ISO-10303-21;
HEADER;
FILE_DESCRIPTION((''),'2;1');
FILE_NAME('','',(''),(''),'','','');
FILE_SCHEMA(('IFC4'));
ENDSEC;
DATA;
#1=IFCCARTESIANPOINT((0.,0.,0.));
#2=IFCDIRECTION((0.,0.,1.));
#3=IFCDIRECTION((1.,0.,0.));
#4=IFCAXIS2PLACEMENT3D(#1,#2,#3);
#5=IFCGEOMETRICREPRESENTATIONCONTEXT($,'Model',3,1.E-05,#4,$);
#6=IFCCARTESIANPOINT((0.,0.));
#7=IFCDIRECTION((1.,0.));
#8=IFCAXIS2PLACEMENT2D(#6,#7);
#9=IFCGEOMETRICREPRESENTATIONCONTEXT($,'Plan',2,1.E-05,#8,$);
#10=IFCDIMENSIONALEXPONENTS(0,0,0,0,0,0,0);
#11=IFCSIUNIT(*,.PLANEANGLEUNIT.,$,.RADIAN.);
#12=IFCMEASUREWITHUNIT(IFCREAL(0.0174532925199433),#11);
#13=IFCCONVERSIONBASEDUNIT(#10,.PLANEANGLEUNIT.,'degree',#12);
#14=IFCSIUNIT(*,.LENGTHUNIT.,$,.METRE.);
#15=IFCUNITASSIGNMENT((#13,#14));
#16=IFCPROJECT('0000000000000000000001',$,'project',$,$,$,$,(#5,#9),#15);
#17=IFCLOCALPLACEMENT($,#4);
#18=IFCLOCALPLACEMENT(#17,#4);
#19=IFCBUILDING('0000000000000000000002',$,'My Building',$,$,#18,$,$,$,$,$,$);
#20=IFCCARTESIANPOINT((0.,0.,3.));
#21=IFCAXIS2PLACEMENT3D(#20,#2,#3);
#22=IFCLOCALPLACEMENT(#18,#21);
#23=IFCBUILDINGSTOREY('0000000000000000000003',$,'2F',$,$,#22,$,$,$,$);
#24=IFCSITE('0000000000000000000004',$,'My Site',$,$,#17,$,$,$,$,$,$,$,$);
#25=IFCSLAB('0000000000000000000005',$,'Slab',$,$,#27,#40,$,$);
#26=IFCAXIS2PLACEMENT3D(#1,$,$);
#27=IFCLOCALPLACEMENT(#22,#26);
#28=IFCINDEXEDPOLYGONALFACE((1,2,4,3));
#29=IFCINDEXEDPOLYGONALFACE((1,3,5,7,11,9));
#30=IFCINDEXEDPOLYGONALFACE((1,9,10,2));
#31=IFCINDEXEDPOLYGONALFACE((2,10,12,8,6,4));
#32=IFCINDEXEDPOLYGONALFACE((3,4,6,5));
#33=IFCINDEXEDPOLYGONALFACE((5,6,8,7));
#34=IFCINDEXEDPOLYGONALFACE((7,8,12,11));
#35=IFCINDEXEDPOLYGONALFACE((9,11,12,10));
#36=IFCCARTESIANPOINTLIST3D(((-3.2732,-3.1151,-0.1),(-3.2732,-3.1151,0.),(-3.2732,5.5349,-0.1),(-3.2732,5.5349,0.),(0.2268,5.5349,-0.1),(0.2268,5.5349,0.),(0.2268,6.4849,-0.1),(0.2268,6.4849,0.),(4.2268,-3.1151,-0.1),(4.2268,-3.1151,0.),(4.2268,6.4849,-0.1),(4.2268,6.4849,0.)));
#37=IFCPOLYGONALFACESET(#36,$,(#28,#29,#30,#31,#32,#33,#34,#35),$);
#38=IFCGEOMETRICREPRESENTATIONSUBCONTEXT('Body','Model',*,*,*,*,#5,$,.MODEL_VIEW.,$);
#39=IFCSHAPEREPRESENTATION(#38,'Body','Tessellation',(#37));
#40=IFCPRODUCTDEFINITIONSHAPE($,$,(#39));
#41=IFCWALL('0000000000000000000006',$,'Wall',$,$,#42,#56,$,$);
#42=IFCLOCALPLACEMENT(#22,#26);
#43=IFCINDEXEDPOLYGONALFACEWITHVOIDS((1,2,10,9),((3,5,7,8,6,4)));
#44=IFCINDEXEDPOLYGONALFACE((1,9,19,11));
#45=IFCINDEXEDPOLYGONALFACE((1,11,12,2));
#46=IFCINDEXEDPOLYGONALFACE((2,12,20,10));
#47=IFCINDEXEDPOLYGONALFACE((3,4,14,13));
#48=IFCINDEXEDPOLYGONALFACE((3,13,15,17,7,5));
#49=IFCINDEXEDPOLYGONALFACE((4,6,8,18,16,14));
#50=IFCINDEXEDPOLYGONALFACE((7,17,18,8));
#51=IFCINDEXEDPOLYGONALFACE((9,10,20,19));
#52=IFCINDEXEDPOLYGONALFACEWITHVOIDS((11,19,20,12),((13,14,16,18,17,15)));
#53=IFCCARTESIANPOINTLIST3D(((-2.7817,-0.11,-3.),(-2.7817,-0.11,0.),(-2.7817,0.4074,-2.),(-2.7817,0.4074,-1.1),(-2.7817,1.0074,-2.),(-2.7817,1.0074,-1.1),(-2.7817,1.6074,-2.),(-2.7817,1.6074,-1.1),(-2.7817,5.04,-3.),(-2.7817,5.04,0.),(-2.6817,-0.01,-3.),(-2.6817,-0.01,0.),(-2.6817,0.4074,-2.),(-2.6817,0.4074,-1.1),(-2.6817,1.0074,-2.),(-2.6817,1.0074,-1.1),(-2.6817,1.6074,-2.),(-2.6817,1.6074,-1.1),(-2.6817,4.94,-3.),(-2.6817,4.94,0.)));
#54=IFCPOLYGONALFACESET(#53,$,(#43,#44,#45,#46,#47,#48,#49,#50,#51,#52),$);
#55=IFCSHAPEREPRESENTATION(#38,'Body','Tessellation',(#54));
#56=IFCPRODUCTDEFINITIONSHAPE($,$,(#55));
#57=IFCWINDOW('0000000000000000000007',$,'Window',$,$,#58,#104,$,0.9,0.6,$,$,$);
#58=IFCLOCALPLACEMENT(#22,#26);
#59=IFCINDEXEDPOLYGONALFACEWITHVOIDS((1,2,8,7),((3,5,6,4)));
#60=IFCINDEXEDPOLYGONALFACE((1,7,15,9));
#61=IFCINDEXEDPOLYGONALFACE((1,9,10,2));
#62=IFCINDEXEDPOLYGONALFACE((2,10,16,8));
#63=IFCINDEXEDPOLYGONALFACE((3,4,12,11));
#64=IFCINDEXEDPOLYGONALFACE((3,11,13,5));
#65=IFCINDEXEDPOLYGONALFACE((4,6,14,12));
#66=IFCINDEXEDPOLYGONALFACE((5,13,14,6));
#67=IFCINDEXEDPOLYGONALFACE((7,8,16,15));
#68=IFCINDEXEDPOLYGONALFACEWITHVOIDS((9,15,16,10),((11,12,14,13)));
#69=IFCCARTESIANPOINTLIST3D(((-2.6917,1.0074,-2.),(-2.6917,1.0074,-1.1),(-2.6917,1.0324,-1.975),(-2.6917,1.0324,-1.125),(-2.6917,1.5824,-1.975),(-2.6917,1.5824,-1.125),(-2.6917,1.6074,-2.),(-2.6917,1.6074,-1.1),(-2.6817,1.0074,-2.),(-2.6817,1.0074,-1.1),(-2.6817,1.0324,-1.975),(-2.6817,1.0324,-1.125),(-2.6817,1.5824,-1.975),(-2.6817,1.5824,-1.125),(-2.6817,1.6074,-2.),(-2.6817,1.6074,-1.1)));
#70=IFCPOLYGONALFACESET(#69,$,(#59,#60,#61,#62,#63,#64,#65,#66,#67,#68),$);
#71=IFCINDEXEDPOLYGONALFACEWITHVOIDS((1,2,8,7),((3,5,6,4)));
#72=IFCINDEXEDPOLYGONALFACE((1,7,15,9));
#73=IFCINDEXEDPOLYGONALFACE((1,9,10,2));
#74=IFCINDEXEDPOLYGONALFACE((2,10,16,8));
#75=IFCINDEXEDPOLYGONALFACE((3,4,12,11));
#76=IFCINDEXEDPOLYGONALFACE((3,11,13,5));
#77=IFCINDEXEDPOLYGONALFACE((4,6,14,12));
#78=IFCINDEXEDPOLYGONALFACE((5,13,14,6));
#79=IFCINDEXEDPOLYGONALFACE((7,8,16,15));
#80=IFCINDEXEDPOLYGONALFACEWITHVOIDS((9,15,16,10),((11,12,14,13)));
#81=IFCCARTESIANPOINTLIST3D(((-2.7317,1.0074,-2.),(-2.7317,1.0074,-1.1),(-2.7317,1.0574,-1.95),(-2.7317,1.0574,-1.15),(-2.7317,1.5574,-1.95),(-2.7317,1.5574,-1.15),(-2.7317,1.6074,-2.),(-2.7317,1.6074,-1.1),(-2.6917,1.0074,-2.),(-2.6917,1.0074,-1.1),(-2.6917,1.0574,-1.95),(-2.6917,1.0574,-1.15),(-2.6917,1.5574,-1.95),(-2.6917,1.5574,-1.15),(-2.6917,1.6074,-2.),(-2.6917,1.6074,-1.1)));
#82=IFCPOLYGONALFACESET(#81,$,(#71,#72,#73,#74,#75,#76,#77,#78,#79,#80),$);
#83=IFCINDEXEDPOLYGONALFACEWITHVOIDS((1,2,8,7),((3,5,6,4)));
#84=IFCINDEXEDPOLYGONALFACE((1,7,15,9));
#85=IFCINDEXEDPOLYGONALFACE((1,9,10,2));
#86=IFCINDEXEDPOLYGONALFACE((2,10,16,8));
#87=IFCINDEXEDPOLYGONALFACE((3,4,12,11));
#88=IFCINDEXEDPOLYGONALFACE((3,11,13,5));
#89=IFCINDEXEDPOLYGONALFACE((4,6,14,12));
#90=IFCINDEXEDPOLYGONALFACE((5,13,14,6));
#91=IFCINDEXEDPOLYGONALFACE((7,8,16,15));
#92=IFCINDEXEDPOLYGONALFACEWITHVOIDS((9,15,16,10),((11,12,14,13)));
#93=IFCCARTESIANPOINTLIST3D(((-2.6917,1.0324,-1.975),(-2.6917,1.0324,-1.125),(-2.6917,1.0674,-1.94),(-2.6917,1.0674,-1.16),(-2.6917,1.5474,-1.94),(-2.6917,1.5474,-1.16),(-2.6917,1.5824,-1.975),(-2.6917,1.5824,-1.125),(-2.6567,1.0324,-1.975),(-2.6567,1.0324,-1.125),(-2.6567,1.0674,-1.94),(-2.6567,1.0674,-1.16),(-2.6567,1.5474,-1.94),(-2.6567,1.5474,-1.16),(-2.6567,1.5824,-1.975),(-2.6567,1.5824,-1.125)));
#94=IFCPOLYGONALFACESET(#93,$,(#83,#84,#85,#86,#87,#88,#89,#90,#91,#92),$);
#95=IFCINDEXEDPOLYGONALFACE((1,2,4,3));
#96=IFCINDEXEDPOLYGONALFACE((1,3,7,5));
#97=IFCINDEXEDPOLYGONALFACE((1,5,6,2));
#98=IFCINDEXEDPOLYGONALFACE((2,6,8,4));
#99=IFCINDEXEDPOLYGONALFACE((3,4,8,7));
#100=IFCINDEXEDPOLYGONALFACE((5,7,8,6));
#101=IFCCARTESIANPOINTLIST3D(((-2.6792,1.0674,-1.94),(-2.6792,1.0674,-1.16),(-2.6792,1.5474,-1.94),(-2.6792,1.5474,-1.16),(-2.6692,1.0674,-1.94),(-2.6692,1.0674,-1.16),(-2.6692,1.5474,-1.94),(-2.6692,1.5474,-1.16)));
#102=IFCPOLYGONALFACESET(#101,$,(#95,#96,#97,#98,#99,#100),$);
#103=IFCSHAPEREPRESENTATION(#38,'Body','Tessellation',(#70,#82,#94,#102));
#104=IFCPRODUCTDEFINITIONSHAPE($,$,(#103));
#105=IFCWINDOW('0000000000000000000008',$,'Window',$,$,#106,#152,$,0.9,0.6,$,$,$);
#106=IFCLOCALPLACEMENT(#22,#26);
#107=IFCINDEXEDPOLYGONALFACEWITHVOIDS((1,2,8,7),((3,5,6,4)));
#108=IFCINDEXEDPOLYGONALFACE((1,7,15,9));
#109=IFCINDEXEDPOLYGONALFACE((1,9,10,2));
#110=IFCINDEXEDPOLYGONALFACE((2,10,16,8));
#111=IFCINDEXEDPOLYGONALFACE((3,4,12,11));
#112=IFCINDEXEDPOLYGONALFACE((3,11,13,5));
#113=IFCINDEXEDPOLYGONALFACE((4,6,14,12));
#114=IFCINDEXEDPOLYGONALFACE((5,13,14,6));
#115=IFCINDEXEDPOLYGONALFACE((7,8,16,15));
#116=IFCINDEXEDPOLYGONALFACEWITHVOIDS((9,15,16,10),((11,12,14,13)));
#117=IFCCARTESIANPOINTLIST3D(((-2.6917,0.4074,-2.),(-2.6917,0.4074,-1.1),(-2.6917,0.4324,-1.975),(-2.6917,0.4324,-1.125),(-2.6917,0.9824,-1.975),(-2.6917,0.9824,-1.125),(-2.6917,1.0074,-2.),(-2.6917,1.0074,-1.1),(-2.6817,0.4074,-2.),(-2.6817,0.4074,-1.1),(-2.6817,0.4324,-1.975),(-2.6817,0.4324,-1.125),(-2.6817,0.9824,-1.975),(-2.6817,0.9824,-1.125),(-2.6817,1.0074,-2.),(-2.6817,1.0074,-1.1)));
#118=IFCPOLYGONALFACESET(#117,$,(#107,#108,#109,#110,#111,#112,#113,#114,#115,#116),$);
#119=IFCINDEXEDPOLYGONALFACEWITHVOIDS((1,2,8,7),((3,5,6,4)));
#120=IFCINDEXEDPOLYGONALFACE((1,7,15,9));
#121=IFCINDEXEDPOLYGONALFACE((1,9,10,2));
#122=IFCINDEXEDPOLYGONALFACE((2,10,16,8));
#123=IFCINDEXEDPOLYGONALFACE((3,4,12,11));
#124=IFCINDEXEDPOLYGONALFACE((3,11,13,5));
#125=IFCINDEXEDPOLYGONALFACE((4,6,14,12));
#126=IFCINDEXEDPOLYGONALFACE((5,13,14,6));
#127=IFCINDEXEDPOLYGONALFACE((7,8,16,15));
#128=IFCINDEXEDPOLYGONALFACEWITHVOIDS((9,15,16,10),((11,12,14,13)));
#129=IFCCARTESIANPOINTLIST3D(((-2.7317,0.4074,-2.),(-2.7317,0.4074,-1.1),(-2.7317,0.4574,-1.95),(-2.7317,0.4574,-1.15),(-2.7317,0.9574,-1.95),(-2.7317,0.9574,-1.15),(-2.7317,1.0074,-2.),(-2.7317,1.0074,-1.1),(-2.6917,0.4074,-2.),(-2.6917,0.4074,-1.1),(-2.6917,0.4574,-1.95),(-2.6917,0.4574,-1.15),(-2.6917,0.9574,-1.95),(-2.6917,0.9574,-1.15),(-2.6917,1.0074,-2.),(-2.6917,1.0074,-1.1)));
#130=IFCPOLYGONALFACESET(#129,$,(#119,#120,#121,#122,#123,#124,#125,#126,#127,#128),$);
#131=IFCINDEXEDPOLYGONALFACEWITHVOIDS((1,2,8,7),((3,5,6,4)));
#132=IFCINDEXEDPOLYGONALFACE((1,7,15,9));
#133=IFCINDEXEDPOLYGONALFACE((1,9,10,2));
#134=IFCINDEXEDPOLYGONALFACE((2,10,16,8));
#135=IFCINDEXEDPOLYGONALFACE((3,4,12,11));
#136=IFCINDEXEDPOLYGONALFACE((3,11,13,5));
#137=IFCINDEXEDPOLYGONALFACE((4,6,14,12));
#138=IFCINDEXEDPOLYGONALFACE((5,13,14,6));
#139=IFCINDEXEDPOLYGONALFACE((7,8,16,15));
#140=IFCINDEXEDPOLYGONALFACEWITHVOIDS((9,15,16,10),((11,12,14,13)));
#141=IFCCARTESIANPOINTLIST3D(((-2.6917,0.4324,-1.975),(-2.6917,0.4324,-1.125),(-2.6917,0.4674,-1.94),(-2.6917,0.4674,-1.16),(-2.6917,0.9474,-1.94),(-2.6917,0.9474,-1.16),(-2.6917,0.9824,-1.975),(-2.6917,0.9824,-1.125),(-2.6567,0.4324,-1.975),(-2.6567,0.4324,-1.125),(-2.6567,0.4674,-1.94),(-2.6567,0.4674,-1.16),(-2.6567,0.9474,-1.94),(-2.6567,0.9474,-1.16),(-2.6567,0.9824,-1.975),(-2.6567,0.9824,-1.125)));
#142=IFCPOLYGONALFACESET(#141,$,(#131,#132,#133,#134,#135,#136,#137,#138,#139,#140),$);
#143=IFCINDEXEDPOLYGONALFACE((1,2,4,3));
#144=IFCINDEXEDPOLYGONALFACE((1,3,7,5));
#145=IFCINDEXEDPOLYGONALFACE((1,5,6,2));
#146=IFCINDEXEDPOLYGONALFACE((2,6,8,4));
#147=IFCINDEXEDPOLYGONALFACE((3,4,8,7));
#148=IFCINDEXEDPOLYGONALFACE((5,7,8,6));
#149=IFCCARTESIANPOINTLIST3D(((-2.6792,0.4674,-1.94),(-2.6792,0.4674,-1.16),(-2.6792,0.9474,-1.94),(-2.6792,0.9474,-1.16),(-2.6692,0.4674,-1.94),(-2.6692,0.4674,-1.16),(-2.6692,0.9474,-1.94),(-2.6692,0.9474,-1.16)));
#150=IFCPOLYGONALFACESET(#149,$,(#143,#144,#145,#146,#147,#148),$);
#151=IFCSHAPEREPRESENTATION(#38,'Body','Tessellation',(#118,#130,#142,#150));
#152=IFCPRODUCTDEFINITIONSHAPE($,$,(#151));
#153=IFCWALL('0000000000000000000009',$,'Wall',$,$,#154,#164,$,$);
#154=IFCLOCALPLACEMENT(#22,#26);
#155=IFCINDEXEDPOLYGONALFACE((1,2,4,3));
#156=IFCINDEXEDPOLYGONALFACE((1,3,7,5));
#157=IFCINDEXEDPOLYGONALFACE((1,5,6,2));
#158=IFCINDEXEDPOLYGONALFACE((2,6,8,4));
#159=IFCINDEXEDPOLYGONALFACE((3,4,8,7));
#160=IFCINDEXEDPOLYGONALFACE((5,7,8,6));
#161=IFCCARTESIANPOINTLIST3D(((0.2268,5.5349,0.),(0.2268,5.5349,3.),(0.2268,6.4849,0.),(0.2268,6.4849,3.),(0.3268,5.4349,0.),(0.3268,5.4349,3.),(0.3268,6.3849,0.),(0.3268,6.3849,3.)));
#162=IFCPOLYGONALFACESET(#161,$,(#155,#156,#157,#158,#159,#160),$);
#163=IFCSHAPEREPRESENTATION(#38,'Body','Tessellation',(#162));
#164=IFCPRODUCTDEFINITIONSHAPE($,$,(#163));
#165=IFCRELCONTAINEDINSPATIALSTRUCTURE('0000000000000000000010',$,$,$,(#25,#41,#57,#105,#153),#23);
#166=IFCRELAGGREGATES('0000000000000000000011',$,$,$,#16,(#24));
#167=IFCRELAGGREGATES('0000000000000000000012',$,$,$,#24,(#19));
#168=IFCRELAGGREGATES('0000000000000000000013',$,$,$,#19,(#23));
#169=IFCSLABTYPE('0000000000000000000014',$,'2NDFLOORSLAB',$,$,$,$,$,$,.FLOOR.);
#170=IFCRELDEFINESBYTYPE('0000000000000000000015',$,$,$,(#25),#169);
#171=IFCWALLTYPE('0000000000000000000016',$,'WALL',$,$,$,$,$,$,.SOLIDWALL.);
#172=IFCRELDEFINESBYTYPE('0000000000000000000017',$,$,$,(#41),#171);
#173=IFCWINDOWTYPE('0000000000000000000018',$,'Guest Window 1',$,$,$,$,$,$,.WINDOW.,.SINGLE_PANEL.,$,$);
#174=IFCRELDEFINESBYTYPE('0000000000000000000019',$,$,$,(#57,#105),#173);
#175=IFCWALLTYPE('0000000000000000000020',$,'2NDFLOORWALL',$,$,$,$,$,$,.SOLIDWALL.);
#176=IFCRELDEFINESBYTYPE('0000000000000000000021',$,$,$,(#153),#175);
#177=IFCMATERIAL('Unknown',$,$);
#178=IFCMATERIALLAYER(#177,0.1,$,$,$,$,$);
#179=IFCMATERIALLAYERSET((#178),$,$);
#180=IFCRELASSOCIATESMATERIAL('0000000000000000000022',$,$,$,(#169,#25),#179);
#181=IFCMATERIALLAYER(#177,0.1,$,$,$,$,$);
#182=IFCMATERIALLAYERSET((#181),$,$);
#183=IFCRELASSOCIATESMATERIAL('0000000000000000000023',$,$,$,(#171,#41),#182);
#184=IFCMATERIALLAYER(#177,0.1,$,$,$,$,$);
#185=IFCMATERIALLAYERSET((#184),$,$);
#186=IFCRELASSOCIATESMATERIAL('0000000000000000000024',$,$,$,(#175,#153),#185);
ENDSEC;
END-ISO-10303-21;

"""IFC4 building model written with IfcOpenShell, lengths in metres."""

from ifc_helpers import new_model, entity, si_unit, converted_unit, frame, origin_with_axes, origin_2d_with_axis, place, context, subcontext, project, spatial, line, indexed_curve, outline, extrude, shape, source, transform, mapped, material, layer, layer_set, layer_usage, type_object, type_shapes, element, fill, save


model = new_model("IFC4")

# Units and contexts
model_context = context("Model", 3, precision=1e-05, world=origin_with_axes())
plan_context = context("Plan", 2, precision=1e-05, world=origin_2d_with_axis())
body_context_1 = subcontext(model_context, "Body", "Model", "MODEL_VIEW")
body_context_2 = subcontext(plan_context, "Body", "Plan", "PLAN_VIEW")
ifc_project = project(units=[converted_unit("PLANEANGLEUNIT", "degree", entity("IfcReal", 0.0174532925199433), si_unit("PLANEANGLEUNIT", "RADIAN"), dimensions=[0, 0, 0, 0, 0, 0, 0]), si_unit("LENGTHUNIT", "METRE")], contexts=[model_context, plan_context])

# Site, building, storey
site_placement = place(None, origin_with_axes())
site = spatial("IfcSite", under=ifc_project, at=site_placement, Name="My Site")
building_placement = place(site_placement, origin_with_axes())
building = spatial("IfcBuilding", under=site, at=building_placement, Name="My Building")
storey_placement = place(building_placement, frame((0.0, 0.0, 3.0), z_axis=(0.0, 0.0, 1.0), x_axis=(1.0, 0.0, 0.0)))
storey = spatial("IfcBuildingStorey", under=building, at=storey_placement, Name="2F")

# Slab
ifc_material = material(Name="Unknown")
ifc_layer_1 = layer(ifc_material, 0.1)
ifc_layer_set_1 = layer_set([ifc_layer_1])
ifc_layer_usage_1 = layer_usage(ifc_layer_set_1, "AXIS3", "POSITIVE", -0.1)
slab_type = type_object("IfcSlabType", Name="2NDFLOORSLAB", PredefinedType="FLOOR", material=ifc_layer_set_1)
slab_placement = place(storey_placement, frame((-3.2732, 5.5349, 0.0), z_axis=(0.0, 0.0, 1.0), x_axis=(1.0, 0.0, 0.0)))
element("IfcSlab", 1, at=slab_placement, inside=storey, type_object=slab_type, material=ifc_layer_usage_1, Name="Slab", context=body_context_1, shape_type="SweptSolid", body=[
    extrude(outline(indexed_curve([(0.0, 0.0), (3.5, 0.0), (3.5, 0.95), (7.5, 0.95), (7.5, -8.65), (0.0, -8.65), (0.0, 0.0)])), frame((0.0, 0.0, -0.1), z_axis=(0.0, 0.0, 1.0), x_axis=(1.0, 0.0, 0.0)), (0.0, 0.0, 1.0), 0.1),
])

# Wall, openings, windows
ifc_layer_2 = layer(ifc_material, 0.1)
ifc_layer_set_2 = layer_set([ifc_layer_2])
ifc_layer_usage_2 = layer_usage(ifc_layer_set_2, "AXIS2", "POSITIVE", 0.0)
wall_type_1 = type_object("IfcWallType", Name="WALL", PredefinedType="SOLIDWALL", material=ifc_layer_set_2)
wall_1_placement = place(storey_placement, frame((-2.7817, 5.04, -3.0), z_axis=(0.0, 0.0, 1.0), x_axis=(0.0, -1.0, 0.0)))
wall_1 = element("IfcWall", 2, at=wall_1_placement, inside=storey, type_object=wall_type_1, material=ifc_layer_usage_2, Name="Wall", context=body_context_1, shape_type="SweptSolid", body=[
    extrude(outline(indexed_curve([(0.0, 0.0), (0.1, 0.1), (5.05, 0.1), (5.15, 0.0)], segments=[line(1, 2, 3, 4, 1)])), origin_with_axes(), (0.0, 0.0, 1.0), 3.0),
])
shared_shape_1 = source(origin_with_axes(), body_context_1, "Body", "SweptSolid", [
    extrude(outline(indexed_curve([(0.0, 0.0), (0.6, 0.0), (0.6, 0.9), (0.0, 0.9)], segments=[line(1, 2, 3, 4, 1)])), frame((0.0, -0.6, 0.0), z_axis=(0.0, -1.0, 0.0), x_axis=(1.0, 0.0, 0.0)), (0.0, 0.0, -1.0), 1.2),
])
opening_1_placement = place(wall_1_placement, frame((3.4326, 0.0, 1.0), z_axis=(0.0, 0.0, 1.0), x_axis=(1.0, 0.0, 0.0)))
opening_1 = element("IfcOpeningElement", 3, at=opening_1_placement, cuts=wall_1, PredefinedType="OPENING", context=body_context_1, shape_type="MappedRepresentation", body=[
    mapped(shared_shape_1, transform((0.0, 0.0, 0.0), x_axis=(1.0, 0.0, 0.0), y_axis=(0.0, 1.0, 0.0), z_axis=(0.0, 0.0, 1.0), scale=1.0)),
])
opening_2_placement = place(wall_1_placement, frame((4.0326, 0.0, 1.0), z_axis=(0.0, 0.0, 1.0), x_axis=(1.0, 0.0, 0.0)))
opening_2 = element("IfcOpeningElement", 4, at=opening_2_placement, cuts=wall_1, PredefinedType="OPENING", context=body_context_1, shape_type="MappedRepresentation", body=[
    mapped(shared_shape_1, transform((0.0, 0.0, 0.0), x_axis=(1.0, 0.0, 0.0), y_axis=(0.0, 1.0, 0.0), z_axis=(0.0, 0.0, 1.0), scale=1.0)),
])
window_type_1 = type_object("IfcWindowType", Name="Guest Window 1", PartitioningType="SINGLE_PANEL", PredefinedType="WINDOW")
shared_shape_2 = source(origin_with_axes(), body_context_1, "Body", "SweptSolid", [
    extrude(outline(indexed_curve([(0.0, 0.0), (0.6, 0.0), (0.6, 0.9), (0.0, 0.9)], segments=[line(1, 2, 3, 4, 1)]), holes=[indexed_curve([(0.025, 0.025), (0.575, 0.025), (0.575, 0.875), (0.025, 0.875)], segments=[line(1, 2, 3, 4, 1)])]), frame((0.0, 0.09, 0.0), z_axis=(0.0, -1.0, 0.0), x_axis=(1.0, 0.0, 0.0)), (0.0, 0.0, -1.0), 0.01),
    extrude(outline(indexed_curve([(0.0, 0.0), (0.6, 0.0), (0.6, 0.9), (0.0, 0.9)], segments=[line(1, 2, 3, 4, 1)]), holes=[indexed_curve([(0.05, 0.05), (0.55, 0.05), (0.55, 0.85), (0.05, 0.85)], segments=[line(1, 2, 3, 4, 1)])]), frame((0.0, 0.05, 0.0), z_axis=(0.0, -1.0, 0.0), x_axis=(1.0, 0.0, 0.0)), (0.0, 0.0, -1.0), 0.04),
    extrude(outline(indexed_curve([(0.0, 0.0), (0.55, 0.0), (0.55, 0.85), (0.0, 0.85)], segments=[line(1, 2, 3, 4, 1)]), holes=[indexed_curve([(0.035, 0.035), (0.515, 0.035), (0.515, 0.815), (0.035, 0.815)], segments=[line(1, 2, 3, 4, 1)])]), frame((0.025, 0.09, 0.025), z_axis=(0.0, -1.0, 0.0), x_axis=(1.0, 0.0, 0.0)), (0.0, 0.0, -1.0), 0.035),
    extrude(outline(indexed_curve([(0.035, 0.035), (0.515, 0.035), (0.515, 0.815), (0.035, 0.815)], segments=[line(1, 2, 3, 4, 1)])), frame((0.025, 0.1025, 0.025), z_axis=(0.0, -1.0, 0.0), x_axis=(1.0, 0.0, 0.0)), (0.0, 0.0, -1.0), 0.01),
])
shared_shape_3 = source(origin_with_axes(), body_context_2, "Body", "Curve2D", [
    entity("IfcIndexedPolyCurve", entity("IfcCartesianPointList2D", [[0.05, 0.05], [0.55, 0.05]])),
    entity("IfcIndexedPolyCurve", entity("IfcCartesianPointList2D", [[0.0, 0.1], [0.025, 0.1], [0.025, 0.09], [0.05, 0.09], [0.05, 0.05], [0.0, 0.05]]), [entity("IfcLineIndex", [1, 2, 3, 4, 5, 6, 1])]),
    entity("IfcIndexedPolyCurve", entity("IfcCartesianPointList2D", [[0.6, 0.1], [0.575, 0.1], [0.575, 0.09], [0.55, 0.09], [0.55, 0.05], [0.6, 0.05]]), [entity("IfcLineIndex", [1, 2, 3, 4, 5, 6, 1])]),
    entity("IfcIndexedPolyCurve", entity("IfcCartesianPointList2D", [[0.025, 0.09], [0.06, 0.09], [0.06, 0.125], [0.025, 0.125]]), [entity("IfcLineIndex", [1, 2, 3, 4, 1])]),
    entity("IfcIndexedPolyCurve", entity("IfcCartesianPointList2D", [[0.575, 0.09], [0.54, 0.09], [0.54, 0.125], [0.575, 0.125]]), [entity("IfcLineIndex", [1, 2, 3, 4, 1])]),
    entity("IfcIndexedPolyCurve", entity("IfcCartesianPointList2D", [[0.06, 0.09], [0.54, 0.09]])),
    entity("IfcIndexedPolyCurve", entity("IfcCartesianPointList2D", [[0.06, 0.125], [0.54, 0.125]])),
    entity("IfcIndexedPolyCurve", entity("IfcCartesianPointList2D", [[0.06, 0.1075], [0.54, 0.1075]])),
])
type_shapes(window_type_1, [shared_shape_2, shared_shape_3])
window_1_placement = place(opening_1_placement, frame((0.0, 0.0, 0.0), z_axis=(0.0, 0.0, 1.0), x_axis=(1.0, 0.0, 0.0)))
window_1 = element("IfcWindow", 5, at=window_1_placement, inside=storey, type_object=window_type_1, Name="Window", OverallHeight=0.9, OverallWidth=0.6, shapes=[
    shape(body_context_1, "Body", "MappedRepresentation", [mapped(shared_shape_2, transform((0.0, 0.0, 0.0), x_axis=(1.0, 0.0, 0.0), y_axis=(0.0, 1.0, 0.0), z_axis=(0.0, 0.0, 1.0), scale=1.0))]),
    shape(body_context_2, "Body", "MappedRepresentation", [mapped(shared_shape_3, transform((0.0, 0.0, 0.0), x_axis=(1.0, 0.0, 0.0), y_axis=(0.0, 1.0, 0.0), z_axis=(0.0, 0.0, 1.0), scale=1.0))]),
])
fill(opening_1, window_1)
window_2_placement = place(opening_2_placement, frame((0.0, 0.0, 0.0), z_axis=(0.0, 0.0, 1.0), x_axis=(1.0, 0.0, 0.0)))
window_2 = element("IfcWindow", 6, at=window_2_placement, inside=storey, type_object=window_type_1, Name="Window", OverallHeight=0.9, OverallWidth=0.6, shapes=[
    shape(body_context_1, "Body", "MappedRepresentation", [mapped(shared_shape_2, transform((0.0, 0.0, 0.0), x_axis=(1.0, 0.0, 0.0), y_axis=(0.0, 1.0, 0.0), z_axis=(0.0, 0.0, 1.0), scale=1.0))]),
    shape(body_context_2, "Body", "MappedRepresentation", [mapped(shared_shape_3, transform((0.0, 0.0, 0.0), x_axis=(1.0, 0.0, 0.0), y_axis=(0.0, 1.0, 0.0), z_axis=(0.0, 0.0, 1.0), scale=1.0))]),
])
fill(opening_2, window_2)

# Wall
ifc_layer_3 = layer(ifc_material, 0.1)
ifc_layer_set_3 = layer_set([ifc_layer_3])
ifc_layer_usage_3 = layer_usage(ifc_layer_set_3, "AXIS2", "POSITIVE", 0.0)
wall_type_2 = type_object("IfcWallType", Name="2NDFLOORWALL", PredefinedType="SOLIDWALL", material=ifc_layer_set_3)
wall_2_placement = place(storey_placement, frame((0.2268, 6.4849, 0.0), z_axis=(0.0, 0.0, 1.0), x_axis=(0.0, -1.0, 0.0)))
element("IfcWall", 7, at=wall_2_placement, inside=storey, type_object=wall_type_2, material=ifc_layer_usage_3, Name="Wall", context=body_context_1, shape_type="SweptSolid", body=[
    extrude(outline(indexed_curve([(0.0, 0.0), (0.1, 0.1), (1.05, 0.1), (0.95, 0.0)], segments=[line(1, 2, 3, 4, 1)])), origin_with_axes(), (0.0, 0.0, 1.0), 3.0),
])

save(model, "model.ifc")
